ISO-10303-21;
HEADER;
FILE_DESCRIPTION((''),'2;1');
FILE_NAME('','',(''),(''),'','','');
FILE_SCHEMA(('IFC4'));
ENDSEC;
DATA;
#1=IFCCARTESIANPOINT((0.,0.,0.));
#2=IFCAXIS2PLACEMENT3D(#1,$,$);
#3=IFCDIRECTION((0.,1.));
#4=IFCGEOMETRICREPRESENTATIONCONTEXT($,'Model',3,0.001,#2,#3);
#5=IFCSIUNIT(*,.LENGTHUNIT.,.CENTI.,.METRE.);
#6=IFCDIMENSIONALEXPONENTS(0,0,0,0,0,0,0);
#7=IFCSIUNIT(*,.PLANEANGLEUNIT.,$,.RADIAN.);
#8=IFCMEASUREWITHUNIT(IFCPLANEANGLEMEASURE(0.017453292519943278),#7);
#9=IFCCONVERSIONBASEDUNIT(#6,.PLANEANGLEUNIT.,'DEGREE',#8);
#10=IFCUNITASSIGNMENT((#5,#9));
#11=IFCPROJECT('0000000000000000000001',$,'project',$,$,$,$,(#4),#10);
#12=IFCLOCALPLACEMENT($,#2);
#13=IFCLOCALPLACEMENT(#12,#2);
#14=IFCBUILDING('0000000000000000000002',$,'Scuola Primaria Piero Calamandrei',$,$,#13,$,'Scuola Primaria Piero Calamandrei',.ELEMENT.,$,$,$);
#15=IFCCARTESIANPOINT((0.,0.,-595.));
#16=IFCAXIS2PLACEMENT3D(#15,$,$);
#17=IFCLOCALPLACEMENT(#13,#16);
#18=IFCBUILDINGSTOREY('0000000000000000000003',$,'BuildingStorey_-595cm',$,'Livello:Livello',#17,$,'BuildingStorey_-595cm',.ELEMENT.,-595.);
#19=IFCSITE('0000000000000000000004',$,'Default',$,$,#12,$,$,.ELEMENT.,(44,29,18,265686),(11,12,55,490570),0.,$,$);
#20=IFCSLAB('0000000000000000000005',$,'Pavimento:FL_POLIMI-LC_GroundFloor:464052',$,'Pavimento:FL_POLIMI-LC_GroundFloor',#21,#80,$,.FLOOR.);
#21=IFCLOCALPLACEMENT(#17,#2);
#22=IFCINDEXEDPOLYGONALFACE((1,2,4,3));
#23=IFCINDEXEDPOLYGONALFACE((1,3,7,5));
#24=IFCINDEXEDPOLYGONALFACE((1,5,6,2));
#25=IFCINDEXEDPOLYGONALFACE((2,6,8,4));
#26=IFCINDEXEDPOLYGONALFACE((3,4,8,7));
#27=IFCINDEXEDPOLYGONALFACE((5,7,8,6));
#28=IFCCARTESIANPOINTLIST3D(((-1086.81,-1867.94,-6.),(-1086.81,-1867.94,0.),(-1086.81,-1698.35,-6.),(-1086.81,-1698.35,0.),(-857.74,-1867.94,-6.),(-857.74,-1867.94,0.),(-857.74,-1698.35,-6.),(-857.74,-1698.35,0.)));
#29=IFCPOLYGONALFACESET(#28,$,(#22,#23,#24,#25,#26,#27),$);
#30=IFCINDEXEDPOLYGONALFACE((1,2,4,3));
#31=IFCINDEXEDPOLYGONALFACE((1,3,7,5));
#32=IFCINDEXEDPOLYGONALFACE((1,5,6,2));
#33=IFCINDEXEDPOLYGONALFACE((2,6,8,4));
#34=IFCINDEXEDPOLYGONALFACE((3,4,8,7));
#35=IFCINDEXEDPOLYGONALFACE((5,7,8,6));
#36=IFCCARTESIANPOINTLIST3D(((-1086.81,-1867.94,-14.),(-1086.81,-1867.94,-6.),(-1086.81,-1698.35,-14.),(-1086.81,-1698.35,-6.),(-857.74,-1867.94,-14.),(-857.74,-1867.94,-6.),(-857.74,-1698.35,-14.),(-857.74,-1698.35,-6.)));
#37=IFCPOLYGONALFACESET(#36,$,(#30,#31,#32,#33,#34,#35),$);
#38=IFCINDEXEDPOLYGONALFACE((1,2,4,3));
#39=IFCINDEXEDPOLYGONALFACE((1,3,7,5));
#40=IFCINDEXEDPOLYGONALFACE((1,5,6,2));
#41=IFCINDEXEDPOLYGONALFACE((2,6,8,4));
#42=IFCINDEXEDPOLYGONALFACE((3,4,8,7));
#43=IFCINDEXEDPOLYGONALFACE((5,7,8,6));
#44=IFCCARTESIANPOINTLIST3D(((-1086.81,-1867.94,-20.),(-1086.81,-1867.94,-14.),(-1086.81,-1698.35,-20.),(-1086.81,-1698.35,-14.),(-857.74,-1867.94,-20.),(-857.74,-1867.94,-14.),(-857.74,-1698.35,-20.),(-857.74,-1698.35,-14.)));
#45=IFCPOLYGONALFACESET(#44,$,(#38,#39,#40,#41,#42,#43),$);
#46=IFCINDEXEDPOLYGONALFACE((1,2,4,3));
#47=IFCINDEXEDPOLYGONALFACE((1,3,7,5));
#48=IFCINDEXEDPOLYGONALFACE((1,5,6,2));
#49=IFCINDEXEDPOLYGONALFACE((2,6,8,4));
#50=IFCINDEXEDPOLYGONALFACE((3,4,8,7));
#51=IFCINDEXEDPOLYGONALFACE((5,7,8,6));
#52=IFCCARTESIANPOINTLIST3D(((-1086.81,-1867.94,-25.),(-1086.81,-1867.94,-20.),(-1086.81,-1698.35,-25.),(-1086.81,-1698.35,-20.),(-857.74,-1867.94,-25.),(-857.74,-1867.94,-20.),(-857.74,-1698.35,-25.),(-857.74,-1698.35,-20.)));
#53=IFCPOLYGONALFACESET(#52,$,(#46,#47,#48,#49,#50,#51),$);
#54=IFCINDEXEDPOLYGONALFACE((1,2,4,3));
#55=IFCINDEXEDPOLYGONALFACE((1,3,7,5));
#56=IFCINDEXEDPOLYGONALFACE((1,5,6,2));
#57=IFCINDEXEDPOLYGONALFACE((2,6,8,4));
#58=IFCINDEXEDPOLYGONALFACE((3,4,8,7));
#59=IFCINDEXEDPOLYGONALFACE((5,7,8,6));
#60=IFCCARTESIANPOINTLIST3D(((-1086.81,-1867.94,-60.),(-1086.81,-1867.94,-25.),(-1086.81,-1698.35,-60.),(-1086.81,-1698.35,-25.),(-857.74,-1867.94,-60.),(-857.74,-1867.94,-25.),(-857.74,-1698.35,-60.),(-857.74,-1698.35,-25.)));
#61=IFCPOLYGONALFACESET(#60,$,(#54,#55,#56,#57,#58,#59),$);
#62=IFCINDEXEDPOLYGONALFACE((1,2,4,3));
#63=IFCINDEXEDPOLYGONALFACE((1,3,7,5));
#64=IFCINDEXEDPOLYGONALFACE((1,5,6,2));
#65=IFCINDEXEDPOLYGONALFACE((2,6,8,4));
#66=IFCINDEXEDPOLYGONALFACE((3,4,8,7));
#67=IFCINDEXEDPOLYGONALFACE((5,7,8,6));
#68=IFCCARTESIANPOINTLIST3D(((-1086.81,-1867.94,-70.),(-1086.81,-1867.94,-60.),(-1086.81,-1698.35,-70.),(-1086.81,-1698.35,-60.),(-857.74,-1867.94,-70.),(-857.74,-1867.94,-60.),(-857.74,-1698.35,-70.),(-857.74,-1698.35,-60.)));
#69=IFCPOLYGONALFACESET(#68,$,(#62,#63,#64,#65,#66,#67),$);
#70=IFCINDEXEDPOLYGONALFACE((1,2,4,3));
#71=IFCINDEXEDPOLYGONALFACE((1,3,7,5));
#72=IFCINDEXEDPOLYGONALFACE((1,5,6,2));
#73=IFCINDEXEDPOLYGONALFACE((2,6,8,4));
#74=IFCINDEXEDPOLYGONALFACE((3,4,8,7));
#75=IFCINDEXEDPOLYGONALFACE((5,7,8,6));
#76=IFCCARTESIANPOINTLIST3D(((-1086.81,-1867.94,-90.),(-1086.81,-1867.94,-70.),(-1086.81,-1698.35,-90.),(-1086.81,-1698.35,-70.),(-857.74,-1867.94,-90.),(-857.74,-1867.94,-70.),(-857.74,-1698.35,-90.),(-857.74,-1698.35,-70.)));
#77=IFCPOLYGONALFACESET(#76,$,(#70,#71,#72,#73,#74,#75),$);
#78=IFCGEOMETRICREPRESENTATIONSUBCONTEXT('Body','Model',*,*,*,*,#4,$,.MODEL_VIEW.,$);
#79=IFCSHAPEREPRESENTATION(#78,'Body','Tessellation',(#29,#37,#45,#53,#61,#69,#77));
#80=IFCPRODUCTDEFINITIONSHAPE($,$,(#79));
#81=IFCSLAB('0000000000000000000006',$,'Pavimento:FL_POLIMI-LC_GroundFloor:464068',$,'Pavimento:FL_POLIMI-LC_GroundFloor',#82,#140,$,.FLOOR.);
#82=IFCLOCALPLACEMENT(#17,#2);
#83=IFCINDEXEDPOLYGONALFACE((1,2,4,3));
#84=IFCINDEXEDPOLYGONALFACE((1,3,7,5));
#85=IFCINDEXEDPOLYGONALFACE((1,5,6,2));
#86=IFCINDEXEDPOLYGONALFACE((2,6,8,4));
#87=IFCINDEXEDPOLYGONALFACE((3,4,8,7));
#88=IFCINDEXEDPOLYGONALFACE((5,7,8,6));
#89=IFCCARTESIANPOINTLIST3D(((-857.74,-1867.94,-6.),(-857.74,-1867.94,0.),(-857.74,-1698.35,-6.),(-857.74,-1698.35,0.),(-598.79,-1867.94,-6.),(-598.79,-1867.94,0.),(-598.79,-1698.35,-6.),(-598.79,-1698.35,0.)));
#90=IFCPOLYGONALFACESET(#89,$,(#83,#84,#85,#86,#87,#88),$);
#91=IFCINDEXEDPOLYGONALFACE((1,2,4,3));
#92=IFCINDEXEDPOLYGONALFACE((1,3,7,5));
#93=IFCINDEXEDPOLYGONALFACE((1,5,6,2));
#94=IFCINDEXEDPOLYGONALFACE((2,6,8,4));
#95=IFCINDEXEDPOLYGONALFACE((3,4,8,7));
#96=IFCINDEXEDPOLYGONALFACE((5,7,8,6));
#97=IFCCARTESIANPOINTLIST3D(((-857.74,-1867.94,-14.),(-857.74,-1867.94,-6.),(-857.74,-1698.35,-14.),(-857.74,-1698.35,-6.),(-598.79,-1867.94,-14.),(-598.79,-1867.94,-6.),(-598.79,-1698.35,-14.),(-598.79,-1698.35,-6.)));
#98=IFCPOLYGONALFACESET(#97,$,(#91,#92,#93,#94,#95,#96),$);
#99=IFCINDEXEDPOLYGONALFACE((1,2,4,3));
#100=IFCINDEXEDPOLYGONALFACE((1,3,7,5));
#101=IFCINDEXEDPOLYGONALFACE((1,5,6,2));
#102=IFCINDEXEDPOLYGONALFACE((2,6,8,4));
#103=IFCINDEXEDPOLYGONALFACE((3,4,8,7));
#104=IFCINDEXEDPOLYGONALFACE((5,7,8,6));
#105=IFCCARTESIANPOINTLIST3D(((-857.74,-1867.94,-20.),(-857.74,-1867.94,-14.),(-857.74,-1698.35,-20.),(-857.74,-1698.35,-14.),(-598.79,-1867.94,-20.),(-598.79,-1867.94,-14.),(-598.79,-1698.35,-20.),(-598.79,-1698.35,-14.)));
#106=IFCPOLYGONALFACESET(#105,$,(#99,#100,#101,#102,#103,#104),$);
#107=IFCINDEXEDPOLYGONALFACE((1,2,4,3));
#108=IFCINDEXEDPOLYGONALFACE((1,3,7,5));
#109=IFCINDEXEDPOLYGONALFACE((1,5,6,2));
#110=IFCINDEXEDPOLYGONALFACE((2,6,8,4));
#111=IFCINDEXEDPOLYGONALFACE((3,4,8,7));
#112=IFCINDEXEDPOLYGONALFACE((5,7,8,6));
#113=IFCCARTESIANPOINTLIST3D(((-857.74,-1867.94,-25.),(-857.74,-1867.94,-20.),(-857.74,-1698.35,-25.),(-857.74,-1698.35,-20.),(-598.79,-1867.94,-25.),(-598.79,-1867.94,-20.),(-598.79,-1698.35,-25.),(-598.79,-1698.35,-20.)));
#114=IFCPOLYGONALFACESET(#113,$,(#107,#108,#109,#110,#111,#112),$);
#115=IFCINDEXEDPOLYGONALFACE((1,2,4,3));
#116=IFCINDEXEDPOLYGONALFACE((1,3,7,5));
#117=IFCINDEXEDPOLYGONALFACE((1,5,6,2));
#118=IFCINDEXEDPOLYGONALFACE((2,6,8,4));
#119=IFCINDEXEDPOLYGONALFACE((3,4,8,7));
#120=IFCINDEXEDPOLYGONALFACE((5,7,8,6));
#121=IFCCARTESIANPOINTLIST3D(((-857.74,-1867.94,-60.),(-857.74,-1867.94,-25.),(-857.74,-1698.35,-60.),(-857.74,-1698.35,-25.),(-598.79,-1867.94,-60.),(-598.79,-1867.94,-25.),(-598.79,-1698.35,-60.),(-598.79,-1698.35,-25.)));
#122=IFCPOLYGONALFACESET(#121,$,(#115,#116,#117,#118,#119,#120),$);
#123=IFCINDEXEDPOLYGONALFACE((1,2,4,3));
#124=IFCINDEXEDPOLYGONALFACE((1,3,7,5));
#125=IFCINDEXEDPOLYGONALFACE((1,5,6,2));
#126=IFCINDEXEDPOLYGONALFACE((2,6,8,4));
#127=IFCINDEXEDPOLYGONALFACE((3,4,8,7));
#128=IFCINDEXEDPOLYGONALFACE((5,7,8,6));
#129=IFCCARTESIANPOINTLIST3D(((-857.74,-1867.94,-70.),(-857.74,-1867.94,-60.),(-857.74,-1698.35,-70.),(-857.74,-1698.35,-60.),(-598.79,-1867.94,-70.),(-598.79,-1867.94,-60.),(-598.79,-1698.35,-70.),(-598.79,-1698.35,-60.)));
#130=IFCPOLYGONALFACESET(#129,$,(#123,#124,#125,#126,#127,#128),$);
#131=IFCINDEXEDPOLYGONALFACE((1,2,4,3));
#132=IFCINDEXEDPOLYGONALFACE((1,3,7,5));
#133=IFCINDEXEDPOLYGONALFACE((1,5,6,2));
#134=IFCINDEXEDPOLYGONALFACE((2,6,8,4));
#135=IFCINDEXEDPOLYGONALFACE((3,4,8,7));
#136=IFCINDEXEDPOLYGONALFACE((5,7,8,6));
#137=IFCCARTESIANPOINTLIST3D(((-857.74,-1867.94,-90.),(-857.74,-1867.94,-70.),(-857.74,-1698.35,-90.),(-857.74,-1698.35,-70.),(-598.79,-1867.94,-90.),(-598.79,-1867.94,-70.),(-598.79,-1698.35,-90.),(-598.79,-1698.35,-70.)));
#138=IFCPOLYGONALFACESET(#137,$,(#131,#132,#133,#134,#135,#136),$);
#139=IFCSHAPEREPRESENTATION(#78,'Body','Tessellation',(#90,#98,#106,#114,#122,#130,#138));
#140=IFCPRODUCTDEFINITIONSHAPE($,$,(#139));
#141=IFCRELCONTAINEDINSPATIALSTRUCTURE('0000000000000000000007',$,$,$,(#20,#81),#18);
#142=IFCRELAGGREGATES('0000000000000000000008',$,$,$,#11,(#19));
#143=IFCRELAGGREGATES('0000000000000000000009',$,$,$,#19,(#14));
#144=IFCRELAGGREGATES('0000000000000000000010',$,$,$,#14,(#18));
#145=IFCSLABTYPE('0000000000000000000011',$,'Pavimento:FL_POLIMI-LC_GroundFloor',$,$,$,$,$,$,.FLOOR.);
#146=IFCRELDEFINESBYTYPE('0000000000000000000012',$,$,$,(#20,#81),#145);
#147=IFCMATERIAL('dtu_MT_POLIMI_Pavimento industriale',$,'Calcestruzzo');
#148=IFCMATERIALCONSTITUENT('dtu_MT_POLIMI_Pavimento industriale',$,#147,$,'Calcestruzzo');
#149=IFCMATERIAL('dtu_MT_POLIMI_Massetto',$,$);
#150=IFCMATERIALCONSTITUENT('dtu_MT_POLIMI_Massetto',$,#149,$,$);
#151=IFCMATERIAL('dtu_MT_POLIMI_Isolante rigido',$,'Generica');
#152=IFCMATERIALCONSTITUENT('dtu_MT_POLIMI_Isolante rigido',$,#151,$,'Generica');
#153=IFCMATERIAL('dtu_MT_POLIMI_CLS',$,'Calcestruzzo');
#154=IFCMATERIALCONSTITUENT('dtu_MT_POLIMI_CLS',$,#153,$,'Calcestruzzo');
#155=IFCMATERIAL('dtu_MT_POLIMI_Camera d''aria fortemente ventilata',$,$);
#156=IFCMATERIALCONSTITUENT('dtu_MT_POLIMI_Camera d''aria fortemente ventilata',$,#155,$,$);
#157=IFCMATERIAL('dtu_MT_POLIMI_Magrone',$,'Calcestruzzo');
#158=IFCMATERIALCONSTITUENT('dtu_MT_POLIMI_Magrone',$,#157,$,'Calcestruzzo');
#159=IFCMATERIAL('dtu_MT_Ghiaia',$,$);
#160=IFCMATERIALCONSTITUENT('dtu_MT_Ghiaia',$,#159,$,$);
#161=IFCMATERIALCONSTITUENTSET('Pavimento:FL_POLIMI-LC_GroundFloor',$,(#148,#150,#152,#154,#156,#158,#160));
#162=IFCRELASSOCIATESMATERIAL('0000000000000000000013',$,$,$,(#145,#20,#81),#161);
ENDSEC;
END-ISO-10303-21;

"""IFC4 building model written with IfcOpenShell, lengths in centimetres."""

from ifc_helpers import new_model, entity, si_unit, converted_unit, direction, frame, origin, place, context, subcontext, project, spatial, indexed_curve, outline, extrude, material, constituent, constituent_set, type_object, element, save


model = new_model("IFC4")

# Units and contexts
model_context = context("Model", 3, precision=0.001, world=origin(), true_north=direction((0.0, 1.0)))
body_context = subcontext(model_context, "Body", "Model", "MODEL_VIEW")
ifc_project = project(units=[si_unit("LENGTHUNIT", "METRE", prefix="CENTI"), converted_unit("PLANEANGLEUNIT", "DEGREE", entity("IfcPlaneAngleMeasure", 0.017453292519943278), si_unit("PLANEANGLEUNIT", "RADIAN"), dimensions=[0, 0, 0, 0, 0, 0, 0])], contexts=[model_context])

# Site, building, storey
site_placement = place(None, origin())
site = spatial("IfcSite", under=ifc_project, at=site_placement, Name="Default", CompositionType="ELEMENT", RefLatitude=(44, 29, 18, 265686), RefLongitude=(11, 12, 55, 490570), RefElevation=0.0)
building_placement = place(site_placement, origin())
building = spatial("IfcBuilding", under=site, at=building_placement, Name="Scuola Primaria Piero Calamandrei", LongName="Scuola Primaria Piero Calamandrei", CompositionType="ELEMENT")
storey_placement = place(building_placement, frame((0.0, 0.0, -595.0)))
storey = spatial("IfcBuildingStorey", under=building, at=storey_placement, Name="BuildingStorey_-595cm", ObjectType="Livello:Livello", LongName="BuildingStorey_-595cm", CompositionType="ELEMENT", Elevation=-595.0)

# Slabs
ifc_material_1 = material(Name="dtu_MT_POLIMI_Pavimento industriale", Category="Calcestruzzo")
ifc_constituent_1 = constituent(ifc_material_1, Name="dtu_MT_POLIMI_Pavimento industriale", Category="Calcestruzzo")
ifc_material_2 = material(Name="dtu_MT_POLIMI_Massetto")
ifc_constituent_2 = constituent(ifc_material_2, Name="dtu_MT_POLIMI_Massetto")
ifc_material_3 = material(Name="dtu_MT_POLIMI_Isolante rigido", Category="Generica")
ifc_constituent_3 = constituent(ifc_material_3, Name="dtu_MT_POLIMI_Isolante rigido", Category="Generica")
ifc_material_4 = material(Name="dtu_MT_POLIMI_CLS", Category="Calcestruzzo")
ifc_constituent_4 = constituent(ifc_material_4, Name="dtu_MT_POLIMI_CLS", Category="Calcestruzzo")
ifc_material_5 = material(Name="dtu_MT_POLIMI_Camera d'aria fortemente ventilata")
ifc_constituent_5 = constituent(ifc_material_5, Name="dtu_MT_POLIMI_Camera d'aria fortemente ventilata")
ifc_material_6 = material(Name="dtu_MT_POLIMI_Magrone", Category="Calcestruzzo")
ifc_constituent_6 = constituent(ifc_material_6, Name="dtu_MT_POLIMI_Magrone", Category="Calcestruzzo")
ifc_material_7 = material(Name="dtu_MT_Ghiaia")
ifc_constituent_7 = constituent(ifc_material_7, Name="dtu_MT_Ghiaia")
ifc_constituent_set_1 = constituent_set(constituents=[ifc_constituent_1, ifc_constituent_2, ifc_constituent_3, ifc_constituent_4, ifc_constituent_5, ifc_constituent_6, ifc_constituent_7], Name="Pavimento:FL_POLIMI-LC_GroundFloor")
slab_type = type_object("IfcSlabType", Name="Pavimento:FL_POLIMI-LC_GroundFloor", PredefinedType="FLOOR", material=ifc_constituent_set_1)
slab_1_placement = place(storey_placement, origin())
element("IfcSlab", 1, at=slab_1_placement, inside=storey, type_object=slab_type, material=ifc_constituent_set_1, Name="Pavimento:FL_POLIMI-LC_GroundFloor:464052", ObjectType="Pavimento:FL_POLIMI-LC_GroundFloor", PredefinedType="FLOOR", context=body_context, shape_type="SweptSolid", body=[
    extrude(outline(indexed_curve([(-114.54, -84.79), (114.54, -84.79), (114.54, 84.79), (-114.54, 84.79), (-114.54, -84.79)], self_intersect=False)), frame((-972.28, -1783.15, -6.0), z_axis=(0.0, 0.0, 1.0), x_axis=(-1.0, 0.0, 0.0)), (0.0, 0.0, 1.0), 6.0),
    extrude(outline(indexed_curve([(-114.54, -84.79), (114.54, -84.79), (114.54, 84.79), (-114.54, 84.79), (-114.54, -84.79)], self_intersect=False)), frame((-972.28, -1783.15, -14.0), z_axis=(0.0, 0.0, 1.0), x_axis=(-1.0, 0.0, 0.0)), (0.0, 0.0, 1.0), 8.0),
    extrude(outline(indexed_curve([(-114.54, -84.79), (114.54, -84.79), (114.54, 84.79), (-114.54, 84.79), (-114.54, -84.79)], self_intersect=False)), frame((-972.28, -1783.15, -20.0), z_axis=(0.0, 0.0, 1.0), x_axis=(-1.0, 0.0, 0.0)), (0.0, 0.0, 1.0), 6.0),
    extrude(outline(indexed_curve([(-114.54, -84.79), (114.54, -84.79), (114.54, 84.79), (-114.54, 84.79), (-114.54, -84.79)], self_intersect=False)), frame((-972.28, -1783.15, -25.0), z_axis=(0.0, 0.0, 1.0), x_axis=(-1.0, 0.0, 0.0)), (0.0, 0.0, 1.0), 5.0),
    extrude(outline(indexed_curve([(-114.54, -84.79), (114.54, -84.79), (114.54, 84.79), (-114.54, 84.79), (-114.54, -84.79)], self_intersect=False)), frame((-972.28, -1783.15, -60.0), z_axis=(0.0, 0.0, 1.0), x_axis=(-1.0, 0.0, 0.0)), (0.0, 0.0, 1.0), 35.0),
    extrude(outline(indexed_curve([(-114.54, -84.79), (114.54, -84.79), (114.54, 84.79), (-114.54, 84.79), (-114.54, -84.79)], self_intersect=False)), frame((-972.28, -1783.15, -70.0), z_axis=(0.0, 0.0, 1.0), x_axis=(-1.0, 0.0, 0.0)), (0.0, 0.0, 1.0), 10.0),
    extrude(outline(indexed_curve([(-114.54, -84.79), (114.54, -84.79), (114.54, 84.79), (-114.54, 84.79), (-114.54, -84.79)], self_intersect=False)), frame((-972.28, -1783.15, -90.0), z_axis=(0.0, 0.0, 1.0), x_axis=(-1.0, 0.0, 0.0)), (0.0, 0.0, 1.0), 20.0),
])
slab_2_placement = place(storey_placement, origin())
element("IfcSlab", 2, at=slab_2_placement, inside=storey, type_object=slab_type, material=ifc_constituent_set_1, Name="Pavimento:FL_POLIMI-LC_GroundFloor:464068", ObjectType="Pavimento:FL_POLIMI-LC_GroundFloor", PredefinedType="FLOOR", context=body_context, shape_type="SweptSolid", body=[
    extrude(outline(indexed_curve([(-84.79, -129.48), (84.79, -129.48), (84.79, 129.48), (-84.79, 129.48), (-84.79, -129.48)], self_intersect=False)), frame((-728.27, -1783.15, -6.0), z_axis=(0.0, 0.0, 1.0), x_axis=(0.0, -1.0, 0.0)), (0.0, 0.0, 1.0), 6.0),
    extrude(outline(indexed_curve([(-84.79, -129.48), (84.79, -129.48), (84.79, 129.48), (-84.79, 129.48), (-84.79, -129.48)], self_intersect=False)), frame((-728.27, -1783.15, -14.0), z_axis=(0.0, 0.0, 1.0), x_axis=(0.0, -1.0, 0.0)), (0.0, 0.0, 1.0), 8.0),
    extrude(outline(indexed_curve([(-84.79, -129.48), (84.79, -129.48), (84.79, 129.48), (-84.79, 129.48), (-84.79, -129.48)], self_intersect=False)), frame((-728.27, -1783.15, -20.0), z_axis=(0.0, 0.0, 1.0), x_axis=(0.0, -1.0, 0.0)), (0.0, 0.0, 1.0), 6.0),
    extrude(outline(indexed_curve([(-84.79, -129.48), (84.79, -129.48), (84.79, 129.48), (-84.79, 129.48), (-84.79, -129.48)], self_intersect=False)), frame((-728.27, -1783.15, -25.0), z_axis=(0.0, 0.0, 1.0), x_axis=(0.0, -1.0, 0.0)), (0.0, 0.0, 1.0), 5.0),
    extrude(outline(indexed_curve([(-84.79, -129.48), (84.79, -129.48), (84.79, 129.48), (-84.79, 129.48), (-84.79, -129.48)], self_intersect=False)), frame((-728.27, -1783.15, -60.0), z_axis=(0.0, 0.0, 1.0), x_axis=(0.0, -1.0, 0.0)), (0.0, 0.0, 1.0), 35.0),
    extrude(outline(indexed_curve([(-84.79, -129.48), (84.79, -129.48), (84.79, 129.48), (-84.79, 129.48), (-84.79, -129.48)], self_intersect=False)), frame((-728.27, -1783.15, -70.0), z_axis=(0.0, 0.0, 1.0), x_axis=(0.0, -1.0, 0.0)), (0.0, 0.0, 1.0), 10.0),
    extrude(outline(indexed_curve([(-84.79, -129.48), (84.79, -129.48), (84.79, 129.48), (-84.79, 129.48), (-84.79, -129.48)], self_intersect=False)), frame((-728.27, -1783.15, -90.0), z_axis=(0.0, 0.0, 1.0), x_axis=(0.0, -1.0, 0.0)), (0.0, 0.0, 1.0), 20.0),
])

save(model, "model.ifc")
